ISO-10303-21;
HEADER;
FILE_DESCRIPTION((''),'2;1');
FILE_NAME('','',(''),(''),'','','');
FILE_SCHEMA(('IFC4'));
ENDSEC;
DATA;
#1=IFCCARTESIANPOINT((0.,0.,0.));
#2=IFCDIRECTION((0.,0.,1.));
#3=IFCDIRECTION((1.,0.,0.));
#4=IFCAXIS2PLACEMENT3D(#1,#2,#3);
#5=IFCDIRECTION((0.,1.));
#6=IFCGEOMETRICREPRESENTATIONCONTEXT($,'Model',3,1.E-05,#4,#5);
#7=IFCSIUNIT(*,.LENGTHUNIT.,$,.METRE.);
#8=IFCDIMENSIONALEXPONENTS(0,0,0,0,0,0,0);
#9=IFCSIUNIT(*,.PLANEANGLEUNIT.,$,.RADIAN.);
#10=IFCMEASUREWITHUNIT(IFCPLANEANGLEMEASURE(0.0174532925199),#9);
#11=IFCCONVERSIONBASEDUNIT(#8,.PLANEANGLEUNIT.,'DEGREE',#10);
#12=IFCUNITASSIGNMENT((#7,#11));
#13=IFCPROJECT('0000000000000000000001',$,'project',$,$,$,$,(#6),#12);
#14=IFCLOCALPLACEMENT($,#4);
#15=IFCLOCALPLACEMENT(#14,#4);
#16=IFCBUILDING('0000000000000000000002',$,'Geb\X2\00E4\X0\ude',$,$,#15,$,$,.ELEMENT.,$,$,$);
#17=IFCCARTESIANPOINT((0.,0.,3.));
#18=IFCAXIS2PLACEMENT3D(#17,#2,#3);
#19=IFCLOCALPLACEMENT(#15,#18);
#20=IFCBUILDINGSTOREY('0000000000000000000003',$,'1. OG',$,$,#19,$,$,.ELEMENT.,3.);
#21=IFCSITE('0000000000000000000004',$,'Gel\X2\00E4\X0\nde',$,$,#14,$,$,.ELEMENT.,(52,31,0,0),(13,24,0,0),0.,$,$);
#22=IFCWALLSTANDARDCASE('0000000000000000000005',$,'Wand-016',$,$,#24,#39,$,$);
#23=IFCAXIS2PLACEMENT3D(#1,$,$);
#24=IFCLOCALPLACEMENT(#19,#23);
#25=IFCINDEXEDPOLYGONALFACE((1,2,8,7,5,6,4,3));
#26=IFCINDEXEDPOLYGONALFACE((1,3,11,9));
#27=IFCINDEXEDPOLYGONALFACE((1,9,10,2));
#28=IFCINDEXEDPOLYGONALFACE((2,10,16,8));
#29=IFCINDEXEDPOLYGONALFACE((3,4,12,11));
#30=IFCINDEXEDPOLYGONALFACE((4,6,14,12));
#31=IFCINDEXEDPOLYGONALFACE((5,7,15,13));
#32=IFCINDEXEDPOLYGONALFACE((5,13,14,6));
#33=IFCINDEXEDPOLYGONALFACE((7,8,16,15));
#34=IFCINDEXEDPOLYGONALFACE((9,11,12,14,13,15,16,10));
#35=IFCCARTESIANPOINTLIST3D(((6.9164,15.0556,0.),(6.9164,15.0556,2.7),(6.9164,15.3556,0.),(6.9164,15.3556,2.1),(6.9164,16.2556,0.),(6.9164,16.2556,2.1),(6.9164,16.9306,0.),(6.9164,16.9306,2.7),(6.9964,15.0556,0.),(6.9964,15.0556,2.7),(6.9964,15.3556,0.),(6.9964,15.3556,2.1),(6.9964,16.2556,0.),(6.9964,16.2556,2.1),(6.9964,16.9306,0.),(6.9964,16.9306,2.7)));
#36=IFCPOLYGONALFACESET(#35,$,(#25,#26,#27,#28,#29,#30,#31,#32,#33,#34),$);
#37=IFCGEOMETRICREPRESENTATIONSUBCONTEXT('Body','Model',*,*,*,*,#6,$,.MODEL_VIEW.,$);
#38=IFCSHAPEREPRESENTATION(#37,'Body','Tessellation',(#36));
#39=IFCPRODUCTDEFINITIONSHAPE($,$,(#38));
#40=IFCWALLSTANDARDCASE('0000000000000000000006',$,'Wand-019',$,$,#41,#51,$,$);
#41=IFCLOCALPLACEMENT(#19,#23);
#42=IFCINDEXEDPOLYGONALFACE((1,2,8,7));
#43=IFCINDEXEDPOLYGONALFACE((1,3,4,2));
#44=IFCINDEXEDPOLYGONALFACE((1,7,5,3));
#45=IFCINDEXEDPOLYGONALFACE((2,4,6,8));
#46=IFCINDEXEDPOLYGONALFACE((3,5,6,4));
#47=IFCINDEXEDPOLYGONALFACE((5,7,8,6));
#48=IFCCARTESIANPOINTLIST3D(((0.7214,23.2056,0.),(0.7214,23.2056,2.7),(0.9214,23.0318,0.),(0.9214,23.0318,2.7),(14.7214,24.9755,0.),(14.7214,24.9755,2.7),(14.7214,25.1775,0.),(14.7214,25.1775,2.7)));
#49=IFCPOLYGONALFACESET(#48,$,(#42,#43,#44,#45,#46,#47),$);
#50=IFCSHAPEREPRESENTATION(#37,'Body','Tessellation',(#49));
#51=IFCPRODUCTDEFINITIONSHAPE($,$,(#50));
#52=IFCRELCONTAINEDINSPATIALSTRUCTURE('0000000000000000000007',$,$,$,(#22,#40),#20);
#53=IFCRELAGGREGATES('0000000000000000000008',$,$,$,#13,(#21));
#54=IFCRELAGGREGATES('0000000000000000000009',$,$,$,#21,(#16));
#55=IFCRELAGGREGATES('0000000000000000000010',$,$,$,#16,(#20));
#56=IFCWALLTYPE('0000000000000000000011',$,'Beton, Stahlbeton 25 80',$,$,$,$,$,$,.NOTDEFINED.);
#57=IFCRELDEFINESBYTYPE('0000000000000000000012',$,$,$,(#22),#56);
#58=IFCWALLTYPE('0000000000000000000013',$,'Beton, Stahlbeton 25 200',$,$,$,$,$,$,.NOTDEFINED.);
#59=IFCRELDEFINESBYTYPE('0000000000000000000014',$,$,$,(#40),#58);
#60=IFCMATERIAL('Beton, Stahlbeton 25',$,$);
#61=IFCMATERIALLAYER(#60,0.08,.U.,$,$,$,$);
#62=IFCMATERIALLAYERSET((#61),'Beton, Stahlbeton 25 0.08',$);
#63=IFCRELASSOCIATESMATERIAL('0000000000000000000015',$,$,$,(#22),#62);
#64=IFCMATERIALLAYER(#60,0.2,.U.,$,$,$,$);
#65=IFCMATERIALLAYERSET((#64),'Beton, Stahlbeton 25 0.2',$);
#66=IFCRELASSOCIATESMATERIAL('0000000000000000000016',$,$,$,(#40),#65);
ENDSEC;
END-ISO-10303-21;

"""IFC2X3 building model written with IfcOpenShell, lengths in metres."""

from ifc_helpers import new_model, entity, si_unit, converted_unit, direction, frame, origin_with_axes, origin_2d_with_axis, place, context, subcontext, project, spatial, polyline, rectangle, outline, extrude, material, layer, layer_set, layer_usage, type_object, element, save


model = new_model("IFC2X3")

# Units and contexts
model_context = context("Model", 3, precision=1e-05, world=origin_with_axes(), true_north=direction((0.0, 1.0)))
body_context = subcontext(model_context, "Body", "Model", "MODEL_VIEW")
ifc_project = project(units=[si_unit("LENGTHUNIT", "METRE"), converted_unit("PLANEANGLEUNIT", "DEGREE", entity("IfcPlaneAngleMeasure", 0.0174532925199), si_unit("PLANEANGLEUNIT", "RADIAN"), dimensions=[0, 0, 0, 0, 0, 0, 0])], contexts=[model_context])

# Site, building, storey
site_placement = place(None, origin_with_axes())
site = spatial("IfcSite", under=ifc_project, at=site_placement, Name="Gelände", CompositionType="ELEMENT", RefLatitude=(52, 31, 0, 0), RefLongitude=(13, 24, 0, 0), RefElevation=0.0)
building_placement = place(site_placement, origin_with_axes())
building = spatial("IfcBuilding", under=site, at=building_placement, Name="Gebäude", CompositionType="ELEMENT")
storey_placement = place(building_placement, frame((0.0, 0.0, 3.0), z_axis=(0.0, 0.0, 1.0), x_axis=(1.0, 0.0, 0.0)))
storey = spatial("IfcBuildingStorey", under=building, at=storey_placement, Name="1. OG", CompositionType="ELEMENT", Elevation=3.0)

# Shared definitions
ifc_material_1 = material(Name="Beton, Stahlbeton 25")

# Wall, opening
ifc_layer_1 = layer(ifc_material_1, 0.08, ventilated="UNKNOWN")
ifc_layer_set_1 = layer_set([ifc_layer_1], Name="Beton, Stahlbeton 25 0.08")
wall_type_1 = type_object("IfcWallType", Name="Beton, Stahlbeton 25 80", PredefinedType="NOTDEFINED")
ifc_layer_usage_1 = layer_usage(ifc_layer_set_1, "AXIS2", "POSITIVE", 0.0)
wall_1_placement = place(storey_placement, frame((6.9164, 16.9306, 0.0), z_axis=(0.0, 0.0, 1.0), x_axis=(0.0, -1.0, 0.0)))
wall_1 = element("IfcWallStandardCase", 1, at=wall_1_placement, inside=storey, type_object=wall_type_1, material=ifc_layer_usage_1, Name="Wand-016", context=body_context, shape_type="SweptSolid", body=[
    extrude(outline(polyline([(0.0, 0.0), (1.875, 0.0), (1.875, 0.08), (0.0, 0.08), (0.0, 0.0)])), origin_with_axes(), (0.0, 0.0, 1.0), 2.7),
])
opening_1_placement = place(wall_1_placement, frame((1.125, 0.0, 0.0), z_axis=(0.0, 0.0, 1.0), x_axis=(1.0, 0.0, 0.0)))
element("IfcOpeningElement", 2, at=opening_1_placement, cuts=wall_1, context=body_context, shape_type="SweptSolid", body=[
    extrude(rectangle(XDim=0.9, YDim=2.1, at=origin_2d_with_axis()), frame((0.0, -0.08, 1.05), z_axis=(0.0, 1.0, 0.0), x_axis=(1.0, 0.0, 0.0)), (0.0, 0.0, 1.0), 0.08),
    extrude(rectangle(XDim=0.9, YDim=2.1, at=origin_2d_with_axis()), frame((0.0, 0.08, 1.05), z_axis=(0.0, -1.0, 0.0), x_axis=(1.0, 0.0, 0.0)), (0.0, 0.0, 1.0), 0.08),
])

# Wall
ifc_layer_2 = layer(ifc_material_1, 0.2, ventilated="UNKNOWN")
ifc_layer_set_2 = layer_set([ifc_layer_2], Name="Beton, Stahlbeton 25 0.2")
ifc_layer_usage_2 = layer_usage(ifc_layer_set_2, "AXIS2", "NEGATIVE", 0.0)
wall_type_2 = type_object("IfcWallType", Name="Beton, Stahlbeton 25 200", PredefinedType="NOTDEFINED")
wall_2_placement = place(storey_placement, frame((0.7214, 23.2056, 0.0), z_axis=(0.0, 0.0, 1.0), x_axis=(0.990227, 0.139469, 0.0)))
element("IfcWallStandardCase", 3, at=wall_2_placement, inside=storey, type_object=wall_type_2, material=ifc_layer_usage_2, Name="Wand-019", context=body_context, shape_type="SweptSolid", body=[
    extrude(outline(polyline([(0.1738, -0.2), (14.11, -0.2), (14.1382, 0.0), (0.0, 0.0), (0.1738, -0.2)])), origin_with_axes(), (0.0, 0.0, 1.0), 2.7),
])

save(model, "model.ifc")
